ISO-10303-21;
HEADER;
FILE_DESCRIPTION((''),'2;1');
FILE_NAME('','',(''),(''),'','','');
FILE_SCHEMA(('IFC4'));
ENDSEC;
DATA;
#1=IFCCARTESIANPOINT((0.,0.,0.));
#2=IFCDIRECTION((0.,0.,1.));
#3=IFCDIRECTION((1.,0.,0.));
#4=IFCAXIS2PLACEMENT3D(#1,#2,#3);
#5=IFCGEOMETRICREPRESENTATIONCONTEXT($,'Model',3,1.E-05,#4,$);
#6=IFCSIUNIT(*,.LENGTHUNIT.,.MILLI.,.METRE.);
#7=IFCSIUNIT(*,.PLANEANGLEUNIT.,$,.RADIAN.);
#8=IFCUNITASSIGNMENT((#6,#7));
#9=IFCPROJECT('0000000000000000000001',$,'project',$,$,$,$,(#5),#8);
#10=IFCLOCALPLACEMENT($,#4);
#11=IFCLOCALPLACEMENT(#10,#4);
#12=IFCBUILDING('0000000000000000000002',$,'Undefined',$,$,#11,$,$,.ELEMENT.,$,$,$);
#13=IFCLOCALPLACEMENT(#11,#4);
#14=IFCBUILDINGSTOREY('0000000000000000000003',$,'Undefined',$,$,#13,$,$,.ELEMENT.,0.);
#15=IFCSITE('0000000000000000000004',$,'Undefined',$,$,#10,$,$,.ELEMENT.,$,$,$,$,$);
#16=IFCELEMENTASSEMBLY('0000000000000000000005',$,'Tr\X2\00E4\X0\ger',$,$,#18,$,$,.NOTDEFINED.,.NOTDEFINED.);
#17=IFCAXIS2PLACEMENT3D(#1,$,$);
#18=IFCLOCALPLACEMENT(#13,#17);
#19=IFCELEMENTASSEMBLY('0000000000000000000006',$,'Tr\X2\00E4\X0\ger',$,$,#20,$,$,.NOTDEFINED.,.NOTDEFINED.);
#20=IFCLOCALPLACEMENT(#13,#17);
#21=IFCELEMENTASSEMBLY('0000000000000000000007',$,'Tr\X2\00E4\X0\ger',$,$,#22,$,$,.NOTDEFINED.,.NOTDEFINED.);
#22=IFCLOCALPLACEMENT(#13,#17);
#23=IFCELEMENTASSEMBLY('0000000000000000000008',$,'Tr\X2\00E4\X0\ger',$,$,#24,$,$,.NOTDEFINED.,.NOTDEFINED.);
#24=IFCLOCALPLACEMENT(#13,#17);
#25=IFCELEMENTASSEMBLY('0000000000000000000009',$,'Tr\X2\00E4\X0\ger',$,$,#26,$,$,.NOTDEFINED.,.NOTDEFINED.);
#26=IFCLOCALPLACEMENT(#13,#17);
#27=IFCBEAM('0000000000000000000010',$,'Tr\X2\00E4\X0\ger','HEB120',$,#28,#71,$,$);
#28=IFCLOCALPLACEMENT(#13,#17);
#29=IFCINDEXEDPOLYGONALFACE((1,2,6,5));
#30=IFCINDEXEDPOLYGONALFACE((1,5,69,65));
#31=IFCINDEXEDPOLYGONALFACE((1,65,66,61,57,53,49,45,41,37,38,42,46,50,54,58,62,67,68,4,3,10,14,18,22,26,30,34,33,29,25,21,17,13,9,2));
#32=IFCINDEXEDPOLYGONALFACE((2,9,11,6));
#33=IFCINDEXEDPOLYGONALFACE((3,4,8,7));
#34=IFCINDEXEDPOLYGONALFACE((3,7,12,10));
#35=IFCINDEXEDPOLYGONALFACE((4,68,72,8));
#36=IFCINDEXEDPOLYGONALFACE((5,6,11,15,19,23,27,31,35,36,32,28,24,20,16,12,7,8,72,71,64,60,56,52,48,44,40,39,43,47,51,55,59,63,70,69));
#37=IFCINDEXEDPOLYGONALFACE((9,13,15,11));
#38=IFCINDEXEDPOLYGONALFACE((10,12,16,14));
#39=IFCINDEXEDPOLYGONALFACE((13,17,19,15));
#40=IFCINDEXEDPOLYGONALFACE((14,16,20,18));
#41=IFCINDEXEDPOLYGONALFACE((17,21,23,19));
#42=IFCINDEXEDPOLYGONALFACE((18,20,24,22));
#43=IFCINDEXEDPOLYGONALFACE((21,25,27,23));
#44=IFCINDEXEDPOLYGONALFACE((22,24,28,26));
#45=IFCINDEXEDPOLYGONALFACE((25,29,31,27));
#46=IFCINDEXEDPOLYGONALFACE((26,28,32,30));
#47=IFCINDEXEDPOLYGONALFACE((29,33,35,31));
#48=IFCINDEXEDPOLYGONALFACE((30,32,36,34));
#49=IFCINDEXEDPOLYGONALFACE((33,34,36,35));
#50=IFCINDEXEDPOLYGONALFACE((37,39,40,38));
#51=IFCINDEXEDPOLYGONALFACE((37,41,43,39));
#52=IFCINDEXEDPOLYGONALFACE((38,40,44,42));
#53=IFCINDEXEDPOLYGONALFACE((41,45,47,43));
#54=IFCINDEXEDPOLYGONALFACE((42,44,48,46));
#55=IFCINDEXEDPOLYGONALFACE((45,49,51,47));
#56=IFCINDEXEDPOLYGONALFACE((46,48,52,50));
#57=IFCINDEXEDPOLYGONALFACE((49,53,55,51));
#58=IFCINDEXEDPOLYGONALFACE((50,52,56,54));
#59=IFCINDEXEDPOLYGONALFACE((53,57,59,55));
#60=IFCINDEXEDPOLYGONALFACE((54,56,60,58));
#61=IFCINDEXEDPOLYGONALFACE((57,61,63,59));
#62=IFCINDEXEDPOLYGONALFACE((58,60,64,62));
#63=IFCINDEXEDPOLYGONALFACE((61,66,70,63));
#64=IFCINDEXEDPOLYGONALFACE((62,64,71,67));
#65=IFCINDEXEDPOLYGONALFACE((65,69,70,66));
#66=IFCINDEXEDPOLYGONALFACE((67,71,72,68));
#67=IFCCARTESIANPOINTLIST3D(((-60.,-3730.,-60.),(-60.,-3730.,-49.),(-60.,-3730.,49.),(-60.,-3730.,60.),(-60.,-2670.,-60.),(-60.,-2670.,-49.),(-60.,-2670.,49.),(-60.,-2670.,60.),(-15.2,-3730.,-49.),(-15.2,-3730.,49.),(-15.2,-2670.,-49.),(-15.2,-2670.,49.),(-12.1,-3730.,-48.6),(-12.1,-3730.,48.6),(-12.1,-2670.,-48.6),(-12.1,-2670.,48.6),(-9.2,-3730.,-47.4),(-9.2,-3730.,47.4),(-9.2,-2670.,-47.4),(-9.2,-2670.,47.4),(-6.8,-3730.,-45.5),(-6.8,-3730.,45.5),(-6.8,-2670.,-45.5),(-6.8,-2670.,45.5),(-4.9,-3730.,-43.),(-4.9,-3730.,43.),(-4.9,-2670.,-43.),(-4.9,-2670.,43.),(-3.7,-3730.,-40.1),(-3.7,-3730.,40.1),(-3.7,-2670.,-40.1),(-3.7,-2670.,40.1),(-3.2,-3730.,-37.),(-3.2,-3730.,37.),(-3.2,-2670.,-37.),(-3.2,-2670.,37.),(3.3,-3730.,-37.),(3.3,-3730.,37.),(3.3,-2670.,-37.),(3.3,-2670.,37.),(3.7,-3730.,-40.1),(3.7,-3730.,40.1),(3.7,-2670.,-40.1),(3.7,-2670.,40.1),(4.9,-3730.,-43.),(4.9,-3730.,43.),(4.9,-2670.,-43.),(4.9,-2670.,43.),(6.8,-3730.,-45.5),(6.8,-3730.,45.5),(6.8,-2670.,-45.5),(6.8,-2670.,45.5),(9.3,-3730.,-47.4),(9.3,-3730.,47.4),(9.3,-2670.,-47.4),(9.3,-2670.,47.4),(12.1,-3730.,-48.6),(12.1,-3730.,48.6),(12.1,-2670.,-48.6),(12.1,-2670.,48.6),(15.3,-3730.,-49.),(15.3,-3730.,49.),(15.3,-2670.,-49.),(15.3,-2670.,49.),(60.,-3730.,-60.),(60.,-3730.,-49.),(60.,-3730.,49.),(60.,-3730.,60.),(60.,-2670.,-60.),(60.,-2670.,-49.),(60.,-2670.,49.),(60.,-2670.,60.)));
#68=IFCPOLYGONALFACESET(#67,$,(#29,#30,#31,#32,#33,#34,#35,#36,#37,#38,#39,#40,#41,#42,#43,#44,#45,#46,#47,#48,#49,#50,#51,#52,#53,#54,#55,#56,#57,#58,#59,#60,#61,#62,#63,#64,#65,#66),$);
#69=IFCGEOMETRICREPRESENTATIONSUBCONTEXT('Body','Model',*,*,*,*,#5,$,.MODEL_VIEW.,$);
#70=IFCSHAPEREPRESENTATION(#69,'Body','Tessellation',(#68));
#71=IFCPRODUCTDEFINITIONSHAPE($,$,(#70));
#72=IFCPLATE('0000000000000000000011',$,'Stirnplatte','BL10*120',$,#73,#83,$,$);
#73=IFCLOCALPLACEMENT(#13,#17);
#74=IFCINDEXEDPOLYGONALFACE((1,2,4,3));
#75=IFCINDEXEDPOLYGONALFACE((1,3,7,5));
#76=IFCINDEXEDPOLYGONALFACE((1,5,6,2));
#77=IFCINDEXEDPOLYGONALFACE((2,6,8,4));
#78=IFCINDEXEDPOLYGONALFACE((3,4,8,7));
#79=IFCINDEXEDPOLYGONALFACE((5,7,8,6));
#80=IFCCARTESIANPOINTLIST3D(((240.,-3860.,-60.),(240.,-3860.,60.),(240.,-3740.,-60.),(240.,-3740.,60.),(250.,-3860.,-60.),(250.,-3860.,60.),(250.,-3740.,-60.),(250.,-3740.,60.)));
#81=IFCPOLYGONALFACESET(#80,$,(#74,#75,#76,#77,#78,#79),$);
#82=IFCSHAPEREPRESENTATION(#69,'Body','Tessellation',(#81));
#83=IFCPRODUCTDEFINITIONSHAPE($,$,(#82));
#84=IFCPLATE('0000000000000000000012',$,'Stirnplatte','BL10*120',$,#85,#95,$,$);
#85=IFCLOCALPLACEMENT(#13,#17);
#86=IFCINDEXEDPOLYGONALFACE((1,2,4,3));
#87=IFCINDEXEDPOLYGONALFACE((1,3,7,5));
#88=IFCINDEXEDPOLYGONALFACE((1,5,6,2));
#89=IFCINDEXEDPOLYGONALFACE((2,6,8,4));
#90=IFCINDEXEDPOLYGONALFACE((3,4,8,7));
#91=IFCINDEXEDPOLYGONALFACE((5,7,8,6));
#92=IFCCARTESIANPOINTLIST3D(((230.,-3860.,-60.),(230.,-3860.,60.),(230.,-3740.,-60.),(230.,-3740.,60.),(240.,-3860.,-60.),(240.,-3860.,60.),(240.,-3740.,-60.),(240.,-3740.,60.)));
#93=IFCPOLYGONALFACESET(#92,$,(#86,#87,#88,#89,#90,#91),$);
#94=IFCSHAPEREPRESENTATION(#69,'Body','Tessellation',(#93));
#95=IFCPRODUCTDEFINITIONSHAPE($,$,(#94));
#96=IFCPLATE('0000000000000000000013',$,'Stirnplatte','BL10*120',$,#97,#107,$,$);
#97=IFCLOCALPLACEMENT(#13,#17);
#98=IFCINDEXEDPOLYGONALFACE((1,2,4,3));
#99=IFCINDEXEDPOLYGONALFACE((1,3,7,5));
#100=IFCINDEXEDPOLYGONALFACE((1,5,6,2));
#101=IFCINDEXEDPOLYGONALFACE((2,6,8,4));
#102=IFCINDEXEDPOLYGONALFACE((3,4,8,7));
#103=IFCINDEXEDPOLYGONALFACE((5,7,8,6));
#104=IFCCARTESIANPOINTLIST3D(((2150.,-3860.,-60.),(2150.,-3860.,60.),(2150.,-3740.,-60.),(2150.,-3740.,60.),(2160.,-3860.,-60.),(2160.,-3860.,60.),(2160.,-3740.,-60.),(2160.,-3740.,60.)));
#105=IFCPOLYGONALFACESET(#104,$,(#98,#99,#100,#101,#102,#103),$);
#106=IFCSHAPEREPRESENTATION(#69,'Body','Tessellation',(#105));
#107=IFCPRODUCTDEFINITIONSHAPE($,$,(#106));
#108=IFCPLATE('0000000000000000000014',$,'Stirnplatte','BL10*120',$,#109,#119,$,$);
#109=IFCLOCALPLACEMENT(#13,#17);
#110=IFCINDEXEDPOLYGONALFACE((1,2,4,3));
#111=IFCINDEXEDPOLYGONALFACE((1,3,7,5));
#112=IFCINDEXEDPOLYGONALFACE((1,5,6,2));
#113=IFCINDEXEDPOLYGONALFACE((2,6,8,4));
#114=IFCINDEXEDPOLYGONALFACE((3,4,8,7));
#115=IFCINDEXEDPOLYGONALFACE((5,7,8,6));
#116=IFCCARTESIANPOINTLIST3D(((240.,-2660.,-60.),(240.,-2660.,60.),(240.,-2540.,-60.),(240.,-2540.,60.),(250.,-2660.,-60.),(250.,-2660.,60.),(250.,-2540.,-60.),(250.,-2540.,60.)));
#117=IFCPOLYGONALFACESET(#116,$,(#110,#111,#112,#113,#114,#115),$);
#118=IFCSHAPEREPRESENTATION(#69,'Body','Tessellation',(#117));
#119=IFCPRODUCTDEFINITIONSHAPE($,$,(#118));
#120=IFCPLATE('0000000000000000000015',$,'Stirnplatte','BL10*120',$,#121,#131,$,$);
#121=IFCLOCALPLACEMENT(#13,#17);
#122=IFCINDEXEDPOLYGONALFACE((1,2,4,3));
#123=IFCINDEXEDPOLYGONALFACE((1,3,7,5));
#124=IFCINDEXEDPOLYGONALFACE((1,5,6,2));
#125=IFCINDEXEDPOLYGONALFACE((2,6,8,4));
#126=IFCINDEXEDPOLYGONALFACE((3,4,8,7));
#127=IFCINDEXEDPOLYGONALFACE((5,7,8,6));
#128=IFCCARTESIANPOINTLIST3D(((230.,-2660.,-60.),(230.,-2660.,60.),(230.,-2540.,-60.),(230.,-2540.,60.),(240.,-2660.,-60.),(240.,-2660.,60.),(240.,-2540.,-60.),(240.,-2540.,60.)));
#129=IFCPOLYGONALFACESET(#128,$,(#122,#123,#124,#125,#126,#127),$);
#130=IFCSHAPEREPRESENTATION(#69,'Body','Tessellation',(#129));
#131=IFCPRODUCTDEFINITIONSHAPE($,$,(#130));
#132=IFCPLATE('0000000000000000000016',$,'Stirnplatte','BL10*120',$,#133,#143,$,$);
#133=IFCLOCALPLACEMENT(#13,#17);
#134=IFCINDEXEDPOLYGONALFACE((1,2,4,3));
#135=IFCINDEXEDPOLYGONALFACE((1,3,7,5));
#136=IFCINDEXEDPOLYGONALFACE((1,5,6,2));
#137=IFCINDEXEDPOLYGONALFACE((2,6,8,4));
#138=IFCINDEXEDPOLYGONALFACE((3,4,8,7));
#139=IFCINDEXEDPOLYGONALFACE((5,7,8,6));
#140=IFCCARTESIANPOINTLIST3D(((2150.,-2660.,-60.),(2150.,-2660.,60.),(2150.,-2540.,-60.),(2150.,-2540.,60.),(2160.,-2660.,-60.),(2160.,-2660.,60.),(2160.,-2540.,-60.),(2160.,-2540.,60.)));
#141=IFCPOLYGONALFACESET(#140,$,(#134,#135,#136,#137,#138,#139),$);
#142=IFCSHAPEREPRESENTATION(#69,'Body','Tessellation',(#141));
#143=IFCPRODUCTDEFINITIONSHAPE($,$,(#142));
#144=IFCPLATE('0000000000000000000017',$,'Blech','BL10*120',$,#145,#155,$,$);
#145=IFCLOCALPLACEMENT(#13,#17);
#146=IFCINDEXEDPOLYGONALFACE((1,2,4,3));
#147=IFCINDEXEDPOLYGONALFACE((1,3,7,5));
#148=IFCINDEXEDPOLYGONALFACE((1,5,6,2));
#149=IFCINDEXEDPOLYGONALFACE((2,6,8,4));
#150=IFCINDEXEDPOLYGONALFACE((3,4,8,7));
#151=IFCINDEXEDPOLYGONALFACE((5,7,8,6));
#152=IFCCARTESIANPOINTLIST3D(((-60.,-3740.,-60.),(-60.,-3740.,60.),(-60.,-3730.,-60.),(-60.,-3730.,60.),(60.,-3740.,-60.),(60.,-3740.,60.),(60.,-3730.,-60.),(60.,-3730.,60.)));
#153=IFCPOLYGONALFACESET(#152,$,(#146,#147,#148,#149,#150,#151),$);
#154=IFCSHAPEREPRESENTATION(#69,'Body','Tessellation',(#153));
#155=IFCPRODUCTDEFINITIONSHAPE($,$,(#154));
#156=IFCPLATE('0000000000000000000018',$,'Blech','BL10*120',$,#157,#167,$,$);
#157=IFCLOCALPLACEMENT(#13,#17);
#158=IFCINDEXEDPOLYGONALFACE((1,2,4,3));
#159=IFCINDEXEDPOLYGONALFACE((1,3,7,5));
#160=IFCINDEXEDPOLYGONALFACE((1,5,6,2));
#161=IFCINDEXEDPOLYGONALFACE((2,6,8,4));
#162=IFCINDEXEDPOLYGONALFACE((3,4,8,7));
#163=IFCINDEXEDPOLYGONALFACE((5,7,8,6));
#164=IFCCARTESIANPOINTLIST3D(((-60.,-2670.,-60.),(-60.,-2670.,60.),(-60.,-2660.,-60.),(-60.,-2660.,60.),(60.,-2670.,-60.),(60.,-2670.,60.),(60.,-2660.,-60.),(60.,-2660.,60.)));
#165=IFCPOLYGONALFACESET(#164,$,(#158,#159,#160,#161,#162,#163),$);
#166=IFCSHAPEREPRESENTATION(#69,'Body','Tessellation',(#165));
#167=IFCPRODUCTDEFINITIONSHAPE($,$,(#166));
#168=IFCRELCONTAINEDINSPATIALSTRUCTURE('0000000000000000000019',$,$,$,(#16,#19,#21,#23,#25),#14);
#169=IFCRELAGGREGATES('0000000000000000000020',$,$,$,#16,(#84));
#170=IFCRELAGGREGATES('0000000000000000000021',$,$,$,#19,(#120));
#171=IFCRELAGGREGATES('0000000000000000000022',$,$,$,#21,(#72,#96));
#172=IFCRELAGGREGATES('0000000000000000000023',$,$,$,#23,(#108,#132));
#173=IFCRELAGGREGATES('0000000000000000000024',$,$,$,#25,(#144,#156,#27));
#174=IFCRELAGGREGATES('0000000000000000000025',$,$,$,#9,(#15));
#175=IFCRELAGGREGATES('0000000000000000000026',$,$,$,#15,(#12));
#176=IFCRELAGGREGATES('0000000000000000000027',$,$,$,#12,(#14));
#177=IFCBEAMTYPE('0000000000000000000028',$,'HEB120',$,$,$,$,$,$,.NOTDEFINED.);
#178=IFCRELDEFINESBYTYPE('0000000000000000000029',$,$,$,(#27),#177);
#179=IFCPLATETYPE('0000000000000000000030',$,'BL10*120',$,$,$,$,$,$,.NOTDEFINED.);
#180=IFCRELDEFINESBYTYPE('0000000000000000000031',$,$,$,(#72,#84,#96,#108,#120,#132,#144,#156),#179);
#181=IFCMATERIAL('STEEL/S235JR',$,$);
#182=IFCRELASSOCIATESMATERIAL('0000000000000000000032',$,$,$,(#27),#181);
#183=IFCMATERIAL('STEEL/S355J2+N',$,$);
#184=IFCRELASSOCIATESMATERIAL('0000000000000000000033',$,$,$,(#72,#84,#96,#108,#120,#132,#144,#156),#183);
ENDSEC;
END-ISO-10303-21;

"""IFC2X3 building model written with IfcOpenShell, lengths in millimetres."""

from ifc_helpers import new_model, si_unit, frame, origin_with_axes, origin_2d_with_axis, place, context, subcontext, project, spatial, polyline, i_section, outline, extrude, clip, halfspace, material, type_object, element, aggregate, save


model = new_model("IFC2X3")

# Units and contexts
model_context = context("Model", 3, precision=1e-05, world=origin_with_axes())
body_context = subcontext(model_context, "Body", "Model", "MODEL_VIEW")
ifc_project = project(units=[si_unit("LENGTHUNIT", "METRE", prefix="MILLI"), si_unit("PLANEANGLEUNIT", "RADIAN")], contexts=[model_context])

# Site, building, storey
site_placement = place(None, origin_with_axes())
site = spatial("IfcSite", under=ifc_project, at=site_placement, Name="Undefined", CompositionType="ELEMENT")
building_placement = place(site_placement, origin_with_axes())
building = spatial("IfcBuilding", under=site, at=building_placement, Name="Undefined", CompositionType="ELEMENT")
storey_placement = place(building_placement, origin_with_axes())
storey = spatial("IfcBuildingStorey", under=building, at=storey_placement, Name="Undefined", CompositionType="ELEMENT", Elevation=0.0)

# Element assemblies
assembly_1_placement = place(storey_placement, origin_with_axes())
assembly_1 = element("IfcElementAssembly", 1, at=assembly_1_placement, inside=storey, Name="Träger", AssemblyPlace="NOTDEFINED", PredefinedType="NOTDEFINED")
ifc_material_1 = material(Name="STEEL/S235JR")
beam_type = type_object("IfcBeamType", Name="HEB120", PredefinedType="NOTDEFINED")
assembly_2_placement = place(storey_placement, origin_with_axes())
assembly_2 = element("IfcElementAssembly", 2, at=assembly_2_placement, inside=storey, Name="Träger", AssemblyPlace="NOTDEFINED", PredefinedType="NOTDEFINED")
assembly_3_placement = place(storey_placement, origin_with_axes())
assembly_3 = element("IfcElementAssembly", 3, at=assembly_3_placement, inside=storey, Name="Träger", AssemblyPlace="NOTDEFINED", PredefinedType="NOTDEFINED")
assembly_4_placement = place(storey_placement, origin_with_axes())
assembly_4 = element("IfcElementAssembly", 4, at=assembly_4_placement, inside=storey, Name="Träger", AssemblyPlace="NOTDEFINED", PredefinedType="NOTDEFINED")

# Element assembly, beam
assembly_5_placement = place(storey_placement, origin_with_axes())
assembly_5 = element("IfcElementAssembly", 5, at=assembly_5_placement, inside=storey, Name="Träger", AssemblyPlace="NOTDEFINED", PredefinedType="NOTDEFINED")
beam_1_placement = place(assembly_5_placement, frame((0.0, -2670.0, 0.0), z_axis=(0.0, 0.0, 1.0), x_axis=(0.0, -1.0, 0.0)))
beam_1 = element("IfcBeam", 6, at=beam_1_placement, type_object=beam_type, material=ifc_material_1, Name="Träger", Description="HEB120", context=body_context, shape_type="Clipping", body=[
    clip(clip(extrude(i_section(OverallWidth=120.0, OverallDepth=120.0, WebThickness=6.5, FlangeThickness=11.0, FilletRadius=12.0, at=origin_2d_with_axis()), frame((1060.0, 0.0, 0.0), z_axis=(-1.0, 0.0, 0.0), x_axis=(0.0, -1.0, 0.0)), (0.0, 0.0, 1.0), 1060.0), halfspace(frame((1060.0, 0.0, -60.0), z_axis=(-1.0, 0.0, 0.0), x_axis=(0.0, 1.0, 0.0)), True)), halfspace(frame((0.0, 0.0, -60.0), z_axis=(1.0, 0.0, 0.0), x_axis=(0.0, -1.0, 0.0)), True)),
])

# Plates
ifc_material_2 = material(Name="STEEL/S355J2+N")
plate_type = type_object("IfcPlateType", Name="BL10*120", PredefinedType="NOTDEFINED")
plate_1_placement = place(assembly_3_placement, frame((245.0, -3800.0, -60.0), z_axis=(1.0, 0.0, 0.0), x_axis=(0.0, 0.0, 1.0)))
plate_1 = element("IfcPlate", 7, at=plate_1_placement, type_object=plate_type, material=ifc_material_2, Name="Stirnplatte", Description="BL10*120", context=body_context, shape_type="SweptSolid", body=[
    extrude(outline(polyline([(0.0, -60.0), (0.0, 60.0), (120.0, 60.0), (120.0, -60.0), (0.0, -60.0)])), frame((0.0, 0.0, -5.0), z_axis=(0.0, 0.0, 1.0), x_axis=(1.0, 0.0, 0.0)), (0.0, 0.0, 1.0), 10.0),
])
plate_2_placement = place(assembly_1_placement, frame((235.0, -3800.0, -60.0), z_axis=(1.0, 0.0, 0.0), x_axis=(0.0, 0.0, 1.0)))
plate_2 = element("IfcPlate", 8, at=plate_2_placement, type_object=plate_type, material=ifc_material_2, Name="Stirnplatte", Description="BL10*120", context=body_context, shape_type="SweptSolid", body=[
    extrude(outline(polyline([(0.0, -60.0), (0.0, 60.0), (120.0, 60.0), (120.0, -60.0), (0.0, -60.0)])), frame((0.0, 0.0, -5.0), z_axis=(0.0, 0.0, 1.0), x_axis=(1.0, 0.0, 0.0)), (0.0, 0.0, 1.0), 10.0),
])
aggregate(assembly_1, [plate_2])
plate_3_placement = place(assembly_3_placement, frame((2155.0, -3800.0, -60.0), z_axis=(-1.0, 0.0, 0.0), x_axis=(0.0, 0.0, 1.0)))
plate_3 = element("IfcPlate", 9, at=plate_3_placement, type_object=plate_type, material=ifc_material_2, Name="Stirnplatte", Description="BL10*120", context=body_context, shape_type="SweptSolid", body=[
    extrude(outline(polyline([(0.0, -60.0), (0.0, 60.0), (120.0, 60.0), (120.0, -60.0), (0.0, -60.0)])), frame((0.0, 0.0, -5.0), z_axis=(0.0, 0.0, 1.0), x_axis=(1.0, 0.0, 0.0)), (0.0, 0.0, 1.0), 10.0),
])
plate_4_placement = place(assembly_4_placement, frame((245.0, -2600.0, -60.0), z_axis=(1.0, 0.0, 0.0), x_axis=(0.0, 0.0, 1.0)))
plate_4 = element("IfcPlate", 10, at=plate_4_placement, type_object=plate_type, material=ifc_material_2, Name="Stirnplatte", Description="BL10*120", context=body_context, shape_type="SweptSolid", body=[
    extrude(outline(polyline([(0.0, -60.0), (0.0, 60.0), (120.0, 60.0), (120.0, -60.0), (0.0, -60.0)])), frame((0.0, 0.0, -5.0), z_axis=(0.0, 0.0, 1.0), x_axis=(1.0, 0.0, 0.0)), (0.0, 0.0, 1.0), 10.0),
])
plate_5_placement = place(assembly_2_placement, frame((235.0, -2600.0, -60.0), z_axis=(1.0, 0.0, 0.0), x_axis=(0.0, 0.0, 1.0)))
plate_5 = element("IfcPlate", 11, at=plate_5_placement, type_object=plate_type, material=ifc_material_2, Name="Stirnplatte", Description="BL10*120", context=body_context, shape_type="SweptSolid", body=[
    extrude(outline(polyline([(0.0, -60.0), (0.0, 60.0), (120.0, 60.0), (120.0, -60.0), (0.0, -60.0)])), frame((0.0, 0.0, -5.0), z_axis=(0.0, 0.0, 1.0), x_axis=(1.0, 0.0, 0.0)), (0.0, 0.0, 1.0), 10.0),
])
aggregate(assembly_2, [plate_5])
plate_6_placement = place(assembly_4_placement, frame((2155.0, -2600.0, -60.0), z_axis=(-1.0, 0.0, 0.0), x_axis=(0.0, 0.0, 1.0)))
plate_6 = element("IfcPlate", 12, at=plate_6_placement, type_object=plate_type, material=ifc_material_2, Name="Stirnplatte", Description="BL10*120", context=body_context, shape_type="SweptSolid", body=[
    extrude(outline(polyline([(0.0, -60.0), (0.0, 60.0), (120.0, 60.0), (120.0, -60.0), (0.0, -60.0)])), frame((0.0, 0.0, -5.0), z_axis=(0.0, 0.0, 1.0), x_axis=(1.0, 0.0, 0.0)), (0.0, 0.0, 1.0), 10.0),
])
plate_7_placement = place(assembly_5_placement, frame((0.0, -3735.0, -60.0), z_axis=(0.0, 1.0, 0.0), x_axis=(0.0, 0.0, 1.0)))
plate_7 = element("IfcPlate", 13, at=plate_7_placement, type_object=plate_type, material=ifc_material_2, Name="Blech", Description="BL10*120", context=body_context, shape_type="SweptSolid", body=[
    extrude(outline(polyline([(0.0, -60.0), (0.0, 60.0), (120.0, 60.0), (120.0, -60.0), (0.0, -60.0)])), frame((0.0, 0.0, -5.0), z_axis=(0.0, 0.0, 1.0), x_axis=(1.0, 0.0, 0.0)), (0.0, 0.0, 1.0), 10.0),
])
plate_8_placement = place(assembly_5_placement, frame((0.0, -2665.0, -60.0), z_axis=(0.0, -1.0, 0.0), x_axis=(0.0, 0.0, 1.0)))
plate_8 = element("IfcPlate", 14, at=plate_8_placement, type_object=plate_type, material=ifc_material_2, Name="Blech", Description="BL10*120", context=body_context, shape_type="SweptSolid", body=[
    extrude(outline(polyline([(0.0, -60.0), (0.0, 60.0), (120.0, 60.0), (120.0, -60.0), (0.0, -60.0)])), frame((0.0, 0.0, -5.0), z_axis=(0.0, 0.0, 1.0), x_axis=(1.0, 0.0, 0.0)), (0.0, 0.0, 1.0), 10.0),
])

aggregate(assembly_3, [plate_1, plate_3])
aggregate(assembly_4, [plate_4, plate_6])
aggregate(assembly_5, [plate_7, plate_8, beam_1])

save(model, "model.ifc")
